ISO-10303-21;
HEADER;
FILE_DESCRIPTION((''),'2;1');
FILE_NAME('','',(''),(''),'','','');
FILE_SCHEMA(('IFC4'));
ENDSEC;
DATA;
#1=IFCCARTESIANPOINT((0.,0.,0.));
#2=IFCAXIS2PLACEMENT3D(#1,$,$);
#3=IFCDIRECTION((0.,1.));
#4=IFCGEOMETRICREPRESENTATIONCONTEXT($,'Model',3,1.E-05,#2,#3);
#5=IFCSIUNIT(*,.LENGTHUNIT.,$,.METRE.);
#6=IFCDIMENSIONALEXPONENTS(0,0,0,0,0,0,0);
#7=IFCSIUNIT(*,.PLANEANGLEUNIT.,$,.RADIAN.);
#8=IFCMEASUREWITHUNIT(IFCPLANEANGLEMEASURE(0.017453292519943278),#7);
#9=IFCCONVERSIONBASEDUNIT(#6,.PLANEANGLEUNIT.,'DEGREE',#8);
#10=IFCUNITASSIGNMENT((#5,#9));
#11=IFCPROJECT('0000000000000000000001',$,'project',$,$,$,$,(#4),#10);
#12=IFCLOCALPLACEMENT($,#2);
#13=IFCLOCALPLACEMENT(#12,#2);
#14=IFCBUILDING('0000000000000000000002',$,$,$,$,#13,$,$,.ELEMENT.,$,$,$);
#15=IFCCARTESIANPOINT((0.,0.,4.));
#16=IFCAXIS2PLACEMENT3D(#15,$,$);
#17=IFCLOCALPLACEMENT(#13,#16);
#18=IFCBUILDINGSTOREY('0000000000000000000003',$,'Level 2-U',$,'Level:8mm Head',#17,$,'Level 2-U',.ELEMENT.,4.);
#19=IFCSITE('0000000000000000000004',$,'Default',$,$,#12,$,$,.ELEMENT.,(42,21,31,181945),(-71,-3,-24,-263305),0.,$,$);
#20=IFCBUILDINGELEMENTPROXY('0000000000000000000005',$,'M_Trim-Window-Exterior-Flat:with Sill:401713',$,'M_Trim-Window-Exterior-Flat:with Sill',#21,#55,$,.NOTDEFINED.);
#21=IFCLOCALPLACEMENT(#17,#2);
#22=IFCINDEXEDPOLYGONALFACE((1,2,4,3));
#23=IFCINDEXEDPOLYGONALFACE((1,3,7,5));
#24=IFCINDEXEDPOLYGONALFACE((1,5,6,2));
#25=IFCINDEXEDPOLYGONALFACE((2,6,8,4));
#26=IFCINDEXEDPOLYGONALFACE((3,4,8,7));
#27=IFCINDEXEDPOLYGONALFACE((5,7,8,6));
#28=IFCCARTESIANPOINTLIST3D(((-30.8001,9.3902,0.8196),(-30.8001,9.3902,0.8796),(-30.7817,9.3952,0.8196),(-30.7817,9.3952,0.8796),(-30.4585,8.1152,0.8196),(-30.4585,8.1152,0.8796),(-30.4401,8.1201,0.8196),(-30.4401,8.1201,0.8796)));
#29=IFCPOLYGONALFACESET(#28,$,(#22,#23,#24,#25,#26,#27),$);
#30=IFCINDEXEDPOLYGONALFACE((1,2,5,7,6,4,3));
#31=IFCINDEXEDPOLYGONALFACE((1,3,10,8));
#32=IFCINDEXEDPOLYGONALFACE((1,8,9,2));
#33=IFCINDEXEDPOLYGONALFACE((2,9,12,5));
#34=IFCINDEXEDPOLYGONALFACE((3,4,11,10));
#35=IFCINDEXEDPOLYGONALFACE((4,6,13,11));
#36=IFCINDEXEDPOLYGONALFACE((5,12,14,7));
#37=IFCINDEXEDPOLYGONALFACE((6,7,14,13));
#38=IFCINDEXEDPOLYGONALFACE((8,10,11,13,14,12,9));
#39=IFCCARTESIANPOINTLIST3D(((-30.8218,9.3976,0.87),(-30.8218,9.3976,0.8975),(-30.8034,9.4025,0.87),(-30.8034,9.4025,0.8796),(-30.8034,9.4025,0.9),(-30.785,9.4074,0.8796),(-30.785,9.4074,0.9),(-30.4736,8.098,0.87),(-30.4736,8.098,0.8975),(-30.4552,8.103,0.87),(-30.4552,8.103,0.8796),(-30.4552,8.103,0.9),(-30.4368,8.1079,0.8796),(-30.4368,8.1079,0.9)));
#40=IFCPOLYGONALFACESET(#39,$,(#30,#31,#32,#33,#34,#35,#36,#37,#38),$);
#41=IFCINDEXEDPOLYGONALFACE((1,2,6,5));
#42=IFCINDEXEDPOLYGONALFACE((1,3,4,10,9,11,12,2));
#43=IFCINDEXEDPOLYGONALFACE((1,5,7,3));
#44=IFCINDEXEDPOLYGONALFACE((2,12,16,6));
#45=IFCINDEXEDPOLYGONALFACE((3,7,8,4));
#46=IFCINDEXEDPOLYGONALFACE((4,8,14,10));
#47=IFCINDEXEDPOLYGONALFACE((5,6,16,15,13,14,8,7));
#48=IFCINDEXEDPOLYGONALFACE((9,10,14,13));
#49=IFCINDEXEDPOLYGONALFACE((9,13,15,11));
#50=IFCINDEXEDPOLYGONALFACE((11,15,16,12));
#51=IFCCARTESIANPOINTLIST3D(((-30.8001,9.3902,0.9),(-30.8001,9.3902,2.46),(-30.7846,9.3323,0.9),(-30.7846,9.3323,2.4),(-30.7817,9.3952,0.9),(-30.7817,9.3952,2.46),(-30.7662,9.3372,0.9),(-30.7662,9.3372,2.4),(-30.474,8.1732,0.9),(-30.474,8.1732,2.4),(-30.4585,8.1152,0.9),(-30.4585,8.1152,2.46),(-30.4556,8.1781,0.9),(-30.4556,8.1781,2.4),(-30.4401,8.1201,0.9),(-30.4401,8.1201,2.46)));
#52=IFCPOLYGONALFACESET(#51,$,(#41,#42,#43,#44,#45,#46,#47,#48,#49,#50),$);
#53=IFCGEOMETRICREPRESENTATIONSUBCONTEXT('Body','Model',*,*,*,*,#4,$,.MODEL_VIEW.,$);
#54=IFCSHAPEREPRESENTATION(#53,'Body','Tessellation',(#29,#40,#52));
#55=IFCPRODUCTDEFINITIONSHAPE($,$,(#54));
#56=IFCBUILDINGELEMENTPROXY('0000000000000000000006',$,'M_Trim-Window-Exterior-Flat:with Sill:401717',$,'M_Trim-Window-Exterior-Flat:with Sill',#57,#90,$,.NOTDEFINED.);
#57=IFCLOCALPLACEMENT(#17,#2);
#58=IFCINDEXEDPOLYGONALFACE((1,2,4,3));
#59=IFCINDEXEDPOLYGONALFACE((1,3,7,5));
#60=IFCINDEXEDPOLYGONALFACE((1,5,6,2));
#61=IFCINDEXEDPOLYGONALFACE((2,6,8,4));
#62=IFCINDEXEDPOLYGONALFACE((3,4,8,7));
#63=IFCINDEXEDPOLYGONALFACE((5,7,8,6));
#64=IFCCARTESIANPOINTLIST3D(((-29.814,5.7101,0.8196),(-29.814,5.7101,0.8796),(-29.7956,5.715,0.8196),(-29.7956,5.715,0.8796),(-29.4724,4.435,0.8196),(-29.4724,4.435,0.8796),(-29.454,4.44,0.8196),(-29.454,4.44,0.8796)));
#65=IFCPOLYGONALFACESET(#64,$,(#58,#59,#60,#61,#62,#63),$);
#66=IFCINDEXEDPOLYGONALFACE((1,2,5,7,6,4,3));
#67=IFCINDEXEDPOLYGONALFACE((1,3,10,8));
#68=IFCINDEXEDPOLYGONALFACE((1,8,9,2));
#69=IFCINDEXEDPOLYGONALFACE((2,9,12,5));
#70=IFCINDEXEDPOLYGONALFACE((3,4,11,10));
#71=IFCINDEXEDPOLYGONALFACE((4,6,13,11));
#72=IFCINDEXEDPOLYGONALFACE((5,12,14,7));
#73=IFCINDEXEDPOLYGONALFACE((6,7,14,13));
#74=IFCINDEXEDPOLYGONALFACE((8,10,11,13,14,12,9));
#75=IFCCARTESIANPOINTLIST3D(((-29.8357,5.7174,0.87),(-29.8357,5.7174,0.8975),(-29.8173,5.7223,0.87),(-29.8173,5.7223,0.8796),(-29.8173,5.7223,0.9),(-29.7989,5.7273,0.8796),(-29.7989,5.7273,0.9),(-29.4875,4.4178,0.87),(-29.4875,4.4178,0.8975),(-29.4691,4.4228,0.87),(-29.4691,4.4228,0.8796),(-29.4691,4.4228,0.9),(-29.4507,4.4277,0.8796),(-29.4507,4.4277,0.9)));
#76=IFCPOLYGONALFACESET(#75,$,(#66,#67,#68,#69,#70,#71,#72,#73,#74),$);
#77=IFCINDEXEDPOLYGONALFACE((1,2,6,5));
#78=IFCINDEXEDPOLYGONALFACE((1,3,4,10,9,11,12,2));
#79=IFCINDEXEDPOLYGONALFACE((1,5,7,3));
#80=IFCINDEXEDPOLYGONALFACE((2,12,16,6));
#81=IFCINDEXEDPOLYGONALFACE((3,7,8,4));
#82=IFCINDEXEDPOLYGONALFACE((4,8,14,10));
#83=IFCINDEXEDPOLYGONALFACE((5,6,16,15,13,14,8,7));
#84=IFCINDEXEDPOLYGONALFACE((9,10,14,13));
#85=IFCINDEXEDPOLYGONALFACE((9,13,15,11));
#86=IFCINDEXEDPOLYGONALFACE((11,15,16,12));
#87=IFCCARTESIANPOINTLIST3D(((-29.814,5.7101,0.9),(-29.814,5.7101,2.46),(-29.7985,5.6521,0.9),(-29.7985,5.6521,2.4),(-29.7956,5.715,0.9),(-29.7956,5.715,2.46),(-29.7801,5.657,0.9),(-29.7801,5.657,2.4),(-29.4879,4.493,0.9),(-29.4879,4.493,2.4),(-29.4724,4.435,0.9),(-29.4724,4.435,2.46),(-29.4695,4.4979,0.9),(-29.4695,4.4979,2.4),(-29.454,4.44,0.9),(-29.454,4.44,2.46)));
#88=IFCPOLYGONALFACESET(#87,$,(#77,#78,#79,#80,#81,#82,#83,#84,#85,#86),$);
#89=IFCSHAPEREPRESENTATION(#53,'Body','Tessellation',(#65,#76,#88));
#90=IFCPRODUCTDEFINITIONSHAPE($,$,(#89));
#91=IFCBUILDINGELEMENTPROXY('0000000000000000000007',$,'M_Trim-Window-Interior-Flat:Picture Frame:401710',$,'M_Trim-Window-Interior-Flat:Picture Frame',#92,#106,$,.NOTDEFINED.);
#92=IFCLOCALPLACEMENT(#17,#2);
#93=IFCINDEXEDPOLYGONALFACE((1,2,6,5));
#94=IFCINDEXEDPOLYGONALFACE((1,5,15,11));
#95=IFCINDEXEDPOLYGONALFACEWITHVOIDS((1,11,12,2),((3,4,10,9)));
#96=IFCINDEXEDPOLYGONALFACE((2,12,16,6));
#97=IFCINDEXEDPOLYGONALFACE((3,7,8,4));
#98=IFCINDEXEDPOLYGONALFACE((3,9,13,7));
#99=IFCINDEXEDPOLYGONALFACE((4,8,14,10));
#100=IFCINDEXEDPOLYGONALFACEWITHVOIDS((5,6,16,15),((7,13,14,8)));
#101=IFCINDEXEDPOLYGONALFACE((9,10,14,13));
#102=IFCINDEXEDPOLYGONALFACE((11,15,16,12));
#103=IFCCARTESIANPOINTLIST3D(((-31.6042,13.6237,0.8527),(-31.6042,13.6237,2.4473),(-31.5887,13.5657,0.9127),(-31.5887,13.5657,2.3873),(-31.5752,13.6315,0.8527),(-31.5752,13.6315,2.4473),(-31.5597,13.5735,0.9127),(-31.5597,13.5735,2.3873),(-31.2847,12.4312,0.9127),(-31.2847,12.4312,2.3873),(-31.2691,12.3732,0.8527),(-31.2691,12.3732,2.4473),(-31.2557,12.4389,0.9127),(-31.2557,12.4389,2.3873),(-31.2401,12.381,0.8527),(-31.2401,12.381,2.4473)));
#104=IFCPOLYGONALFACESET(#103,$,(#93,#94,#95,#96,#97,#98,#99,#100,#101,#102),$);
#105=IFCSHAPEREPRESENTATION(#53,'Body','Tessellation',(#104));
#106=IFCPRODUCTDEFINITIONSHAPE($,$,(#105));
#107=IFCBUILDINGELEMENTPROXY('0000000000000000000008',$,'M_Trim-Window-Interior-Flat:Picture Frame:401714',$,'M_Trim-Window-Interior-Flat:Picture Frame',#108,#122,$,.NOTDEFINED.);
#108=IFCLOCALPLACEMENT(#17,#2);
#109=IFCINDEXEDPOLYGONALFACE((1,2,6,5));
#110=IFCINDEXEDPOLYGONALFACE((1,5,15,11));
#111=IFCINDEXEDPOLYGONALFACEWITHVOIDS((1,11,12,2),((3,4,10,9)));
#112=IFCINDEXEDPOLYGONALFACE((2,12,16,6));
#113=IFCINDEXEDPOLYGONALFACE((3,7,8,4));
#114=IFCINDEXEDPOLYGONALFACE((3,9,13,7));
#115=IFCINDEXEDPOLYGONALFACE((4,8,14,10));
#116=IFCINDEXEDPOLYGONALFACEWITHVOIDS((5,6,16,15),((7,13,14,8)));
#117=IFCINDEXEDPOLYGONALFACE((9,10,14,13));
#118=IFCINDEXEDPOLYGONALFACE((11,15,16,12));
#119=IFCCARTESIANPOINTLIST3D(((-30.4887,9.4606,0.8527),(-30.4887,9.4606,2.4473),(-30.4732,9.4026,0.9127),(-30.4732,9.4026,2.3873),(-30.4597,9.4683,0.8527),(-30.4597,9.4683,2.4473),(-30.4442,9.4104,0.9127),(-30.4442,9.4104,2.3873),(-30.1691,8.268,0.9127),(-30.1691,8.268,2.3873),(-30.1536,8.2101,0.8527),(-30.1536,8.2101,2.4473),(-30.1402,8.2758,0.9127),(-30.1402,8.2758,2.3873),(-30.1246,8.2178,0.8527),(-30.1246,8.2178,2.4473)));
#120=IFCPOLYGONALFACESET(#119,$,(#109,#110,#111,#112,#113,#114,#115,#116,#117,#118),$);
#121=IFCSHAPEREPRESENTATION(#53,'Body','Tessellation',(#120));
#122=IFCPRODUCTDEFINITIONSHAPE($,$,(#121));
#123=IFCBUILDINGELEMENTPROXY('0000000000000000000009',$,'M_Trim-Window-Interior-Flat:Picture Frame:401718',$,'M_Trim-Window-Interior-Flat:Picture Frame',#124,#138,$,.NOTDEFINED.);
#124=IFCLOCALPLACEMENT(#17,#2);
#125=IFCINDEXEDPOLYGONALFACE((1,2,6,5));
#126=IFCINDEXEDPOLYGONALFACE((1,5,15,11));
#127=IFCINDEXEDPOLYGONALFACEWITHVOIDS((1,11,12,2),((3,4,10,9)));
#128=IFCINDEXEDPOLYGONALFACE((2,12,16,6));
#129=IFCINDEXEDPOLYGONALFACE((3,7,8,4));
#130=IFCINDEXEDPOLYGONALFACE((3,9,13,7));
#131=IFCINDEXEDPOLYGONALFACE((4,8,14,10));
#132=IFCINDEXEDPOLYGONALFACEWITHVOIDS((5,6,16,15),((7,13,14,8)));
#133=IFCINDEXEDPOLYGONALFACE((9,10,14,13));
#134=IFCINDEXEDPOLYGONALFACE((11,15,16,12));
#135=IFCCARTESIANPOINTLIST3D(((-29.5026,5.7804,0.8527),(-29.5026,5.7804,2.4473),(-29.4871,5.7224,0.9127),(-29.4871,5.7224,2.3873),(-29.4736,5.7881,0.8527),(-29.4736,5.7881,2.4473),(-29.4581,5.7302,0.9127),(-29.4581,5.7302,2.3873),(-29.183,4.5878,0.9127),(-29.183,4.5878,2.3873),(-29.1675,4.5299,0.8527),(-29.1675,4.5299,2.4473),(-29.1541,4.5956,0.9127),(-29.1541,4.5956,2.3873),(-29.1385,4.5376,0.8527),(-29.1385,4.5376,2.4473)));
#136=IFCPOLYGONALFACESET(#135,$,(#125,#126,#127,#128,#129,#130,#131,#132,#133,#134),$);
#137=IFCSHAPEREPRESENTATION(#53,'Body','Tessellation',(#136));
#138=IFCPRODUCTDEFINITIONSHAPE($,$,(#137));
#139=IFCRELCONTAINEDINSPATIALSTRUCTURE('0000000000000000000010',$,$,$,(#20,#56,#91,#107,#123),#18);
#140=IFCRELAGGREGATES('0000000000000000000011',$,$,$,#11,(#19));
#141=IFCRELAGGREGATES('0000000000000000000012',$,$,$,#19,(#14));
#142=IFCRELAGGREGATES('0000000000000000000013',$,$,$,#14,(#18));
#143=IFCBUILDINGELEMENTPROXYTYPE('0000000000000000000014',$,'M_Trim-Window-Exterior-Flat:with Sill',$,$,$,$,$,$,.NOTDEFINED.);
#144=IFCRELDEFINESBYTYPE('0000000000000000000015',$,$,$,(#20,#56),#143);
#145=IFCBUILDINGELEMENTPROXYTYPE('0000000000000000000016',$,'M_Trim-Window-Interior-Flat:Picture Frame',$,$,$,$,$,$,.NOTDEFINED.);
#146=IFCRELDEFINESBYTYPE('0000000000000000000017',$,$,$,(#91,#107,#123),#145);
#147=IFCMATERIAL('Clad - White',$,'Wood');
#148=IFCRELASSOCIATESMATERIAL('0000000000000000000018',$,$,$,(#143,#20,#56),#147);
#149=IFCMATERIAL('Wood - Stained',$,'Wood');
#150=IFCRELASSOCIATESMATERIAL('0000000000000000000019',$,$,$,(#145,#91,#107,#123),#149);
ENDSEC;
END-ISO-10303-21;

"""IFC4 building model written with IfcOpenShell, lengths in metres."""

from ifc_helpers import new_model, entity, si_unit, converted_unit, direction, frame, origin, place, context, subcontext, project, spatial, indexed_curve, outline, extrude, source, transform, mapped, material, type_object, type_shapes, element, save


model = new_model("IFC4")

# Units and contexts
model_context = context("Model", 3, precision=1e-05, world=origin(), true_north=direction((0.0, 1.0)))
body_context = subcontext(model_context, "Body", "Model", "MODEL_VIEW")
ifc_project = project(units=[si_unit("LENGTHUNIT", "METRE"), converted_unit("PLANEANGLEUNIT", "DEGREE", entity("IfcPlaneAngleMeasure", 0.017453292519943278), si_unit("PLANEANGLEUNIT", "RADIAN"), dimensions=[0, 0, 0, 0, 0, 0, 0])], contexts=[model_context])

# Site, building, storey
site_placement = place(None, origin())
site = spatial("IfcSite", under=ifc_project, at=site_placement, Name="Default", CompositionType="ELEMENT", RefLatitude=(42, 21, 31, 181945), RefLongitude=(-71, -3, -24, -263305), RefElevation=0.0)
building_placement = place(site_placement, origin())
building = spatial("IfcBuilding", under=site, at=building_placement, CompositionType="ELEMENT")
storey_placement = place(building_placement, frame((0.0, 0.0, 4.0)))
storey = spatial("IfcBuildingStorey", under=building, at=storey_placement, Name="Level 2-U", ObjectType="Level:8mm Head", LongName="Level 2-U", CompositionType="ELEMENT", Elevation=4.0)

# Building element proxies
ifc_material_1 = material(Name="Clad - White", Category="Wood")
ifc_material_2 = material(Name="Wood - Stained", Category="Wood")
building_element_proxy_type_1 = type_object("IfcBuildingElementProxyType", Name="M_Trim-Window-Exterior-Flat:with Sill", PredefinedType="NOTDEFINED", material=ifc_material_1)
shared_shape_1 = source(origin(), body_context, "Body", "SweptSolid", [
    extrude(outline(indexed_curve([(-0.66, -0.03), (0.66, -0.03), (0.66, 0.03), (-0.66, 0.03), (-0.66, -0.03)], self_intersect=False)), frame((0.0, -1.5504, 0.0), z_axis=(0.0, 0.0, 1.0), x_axis=(-1.0, 0.0, 0.0)), (0.0, 0.0, 1.0), 0.019),
    extrude(outline(indexed_curve([(-0.019, -0.0152), (0.0, -0.0152), (0.0, -0.0057), (0.019, -0.0057), (0.019, 0.0148), (0.0, 0.0148), (-0.019, 0.0123), (-0.019, -0.0152)], self_intersect=False)), frame((-0.6727, -1.5148, 0.019), z_axis=(1.0, 0.0, 0.0), x_axis=(0.0, 0.0, -1.0)), (0.0, 0.0, 1.0), 1.3454),
    extrude(outline(indexed_curve([(-0.795, -0.66), (0.765, -0.66), (0.765, -0.6), (-0.735, -0.6), (-0.735, 0.6), (0.765, 0.6), (0.765, 0.66), (-0.795, 0.66), (-0.795, -0.66)], self_intersect=False)), frame((0.0, -0.735, 0.0), z_axis=(0.0, 0.0, 1.0), x_axis=(0.0, -1.0, 0.0)), (0.0, 0.0, 1.0), 0.019),
])
type_shapes(building_element_proxy_type_1, [shared_shape_1])
for number, where, z_axis, x_axis, name in (
    (1, (-30.6109, 8.7577, 2.4), (-0.965926, -0.258819, 0.0), (0.258819, -0.965926, 0.0), "M_Trim-Window-Exterior-Flat:with Sill:401713"),
    (2, (-29.6248, 5.0775, 2.4), (-0.965926, -0.258819, 0.0), (0.258819, -0.965926, 0.0), "M_Trim-Window-Exterior-Flat:with Sill:401717"),
):
    element("IfcBuildingElementProxy", number, at=place(storey_placement, frame(where, z_axis=z_axis, x_axis=x_axis)), inside=storey, type_object=building_element_proxy_type_1, material=ifc_material_1, Name=name, ObjectType="M_Trim-Window-Exterior-Flat:with Sill", PredefinedType="NOTDEFINED", context=body_context, shape_type="MappedRepresentation", body=[
        mapped(shared_shape_1, transform((0.0, 0.0, 0.0), scale=1.0)),
    ])
building_element_proxy_type_2 = type_object("IfcBuildingElementProxyType", Name="M_Trim-Window-Interior-Flat:Picture Frame", PredefinedType="NOTDEFINED", material=ifc_material_2)
shared_shape_2 = source(origin(), body_context, "Body", "SweptSolid", [
    extrude(outline(indexed_curve([(-0.6473, -0.7973), (0.6473, -0.7973), (0.6473, 0.7973), (-0.6473, 0.7973), (-0.6473, -0.7973)], self_intersect=False), holes=[indexed_curve([(-0.5873, -0.7373), (-0.5873, 0.7373), (0.5873, 0.7373), (0.5873, -0.7373), (-0.5873, -0.7373)], self_intersect=False)]), frame((0.0, -0.75, 0.0), z_axis=(0.0, 0.0, 1.0), x_axis=(-1.0, 0.0, 0.0)), (0.0, 0.0, 1.0), 0.03),
])
type_shapes(building_element_proxy_type_2, [shared_shape_2])
for number, where, z_axis, x_axis, name in (
    (3, (-31.4367, 12.9984, 2.4), (0.965926, 0.258819, 0.0), (-0.258819, 0.965926, 0.0), "M_Trim-Window-Interior-Flat:Picture Frame:401710"),
    (4, (-30.3211, 8.8353, 2.4), (0.965926, 0.258819, 0.0), (-0.258819, 0.965926, 0.0), "M_Trim-Window-Interior-Flat:Picture Frame:401714"),
    (5, (-29.335, 5.1551, 2.4), (0.965926, 0.258819, 0.0), (-0.258819, 0.965926, 0.0), "M_Trim-Window-Interior-Flat:Picture Frame:401718"),
):
    element("IfcBuildingElementProxy", number, at=place(storey_placement, frame(where, z_axis=z_axis, x_axis=x_axis)), inside=storey, type_object=building_element_proxy_type_2, material=ifc_material_2, Name=name, ObjectType="M_Trim-Window-Interior-Flat:Picture Frame", PredefinedType="NOTDEFINED", context=body_context, shape_type="MappedRepresentation", body=[
        mapped(shared_shape_2, transform((0.0, 0.0, 0.0), scale=1.0)),
    ])

save(model, "model.ifc")
